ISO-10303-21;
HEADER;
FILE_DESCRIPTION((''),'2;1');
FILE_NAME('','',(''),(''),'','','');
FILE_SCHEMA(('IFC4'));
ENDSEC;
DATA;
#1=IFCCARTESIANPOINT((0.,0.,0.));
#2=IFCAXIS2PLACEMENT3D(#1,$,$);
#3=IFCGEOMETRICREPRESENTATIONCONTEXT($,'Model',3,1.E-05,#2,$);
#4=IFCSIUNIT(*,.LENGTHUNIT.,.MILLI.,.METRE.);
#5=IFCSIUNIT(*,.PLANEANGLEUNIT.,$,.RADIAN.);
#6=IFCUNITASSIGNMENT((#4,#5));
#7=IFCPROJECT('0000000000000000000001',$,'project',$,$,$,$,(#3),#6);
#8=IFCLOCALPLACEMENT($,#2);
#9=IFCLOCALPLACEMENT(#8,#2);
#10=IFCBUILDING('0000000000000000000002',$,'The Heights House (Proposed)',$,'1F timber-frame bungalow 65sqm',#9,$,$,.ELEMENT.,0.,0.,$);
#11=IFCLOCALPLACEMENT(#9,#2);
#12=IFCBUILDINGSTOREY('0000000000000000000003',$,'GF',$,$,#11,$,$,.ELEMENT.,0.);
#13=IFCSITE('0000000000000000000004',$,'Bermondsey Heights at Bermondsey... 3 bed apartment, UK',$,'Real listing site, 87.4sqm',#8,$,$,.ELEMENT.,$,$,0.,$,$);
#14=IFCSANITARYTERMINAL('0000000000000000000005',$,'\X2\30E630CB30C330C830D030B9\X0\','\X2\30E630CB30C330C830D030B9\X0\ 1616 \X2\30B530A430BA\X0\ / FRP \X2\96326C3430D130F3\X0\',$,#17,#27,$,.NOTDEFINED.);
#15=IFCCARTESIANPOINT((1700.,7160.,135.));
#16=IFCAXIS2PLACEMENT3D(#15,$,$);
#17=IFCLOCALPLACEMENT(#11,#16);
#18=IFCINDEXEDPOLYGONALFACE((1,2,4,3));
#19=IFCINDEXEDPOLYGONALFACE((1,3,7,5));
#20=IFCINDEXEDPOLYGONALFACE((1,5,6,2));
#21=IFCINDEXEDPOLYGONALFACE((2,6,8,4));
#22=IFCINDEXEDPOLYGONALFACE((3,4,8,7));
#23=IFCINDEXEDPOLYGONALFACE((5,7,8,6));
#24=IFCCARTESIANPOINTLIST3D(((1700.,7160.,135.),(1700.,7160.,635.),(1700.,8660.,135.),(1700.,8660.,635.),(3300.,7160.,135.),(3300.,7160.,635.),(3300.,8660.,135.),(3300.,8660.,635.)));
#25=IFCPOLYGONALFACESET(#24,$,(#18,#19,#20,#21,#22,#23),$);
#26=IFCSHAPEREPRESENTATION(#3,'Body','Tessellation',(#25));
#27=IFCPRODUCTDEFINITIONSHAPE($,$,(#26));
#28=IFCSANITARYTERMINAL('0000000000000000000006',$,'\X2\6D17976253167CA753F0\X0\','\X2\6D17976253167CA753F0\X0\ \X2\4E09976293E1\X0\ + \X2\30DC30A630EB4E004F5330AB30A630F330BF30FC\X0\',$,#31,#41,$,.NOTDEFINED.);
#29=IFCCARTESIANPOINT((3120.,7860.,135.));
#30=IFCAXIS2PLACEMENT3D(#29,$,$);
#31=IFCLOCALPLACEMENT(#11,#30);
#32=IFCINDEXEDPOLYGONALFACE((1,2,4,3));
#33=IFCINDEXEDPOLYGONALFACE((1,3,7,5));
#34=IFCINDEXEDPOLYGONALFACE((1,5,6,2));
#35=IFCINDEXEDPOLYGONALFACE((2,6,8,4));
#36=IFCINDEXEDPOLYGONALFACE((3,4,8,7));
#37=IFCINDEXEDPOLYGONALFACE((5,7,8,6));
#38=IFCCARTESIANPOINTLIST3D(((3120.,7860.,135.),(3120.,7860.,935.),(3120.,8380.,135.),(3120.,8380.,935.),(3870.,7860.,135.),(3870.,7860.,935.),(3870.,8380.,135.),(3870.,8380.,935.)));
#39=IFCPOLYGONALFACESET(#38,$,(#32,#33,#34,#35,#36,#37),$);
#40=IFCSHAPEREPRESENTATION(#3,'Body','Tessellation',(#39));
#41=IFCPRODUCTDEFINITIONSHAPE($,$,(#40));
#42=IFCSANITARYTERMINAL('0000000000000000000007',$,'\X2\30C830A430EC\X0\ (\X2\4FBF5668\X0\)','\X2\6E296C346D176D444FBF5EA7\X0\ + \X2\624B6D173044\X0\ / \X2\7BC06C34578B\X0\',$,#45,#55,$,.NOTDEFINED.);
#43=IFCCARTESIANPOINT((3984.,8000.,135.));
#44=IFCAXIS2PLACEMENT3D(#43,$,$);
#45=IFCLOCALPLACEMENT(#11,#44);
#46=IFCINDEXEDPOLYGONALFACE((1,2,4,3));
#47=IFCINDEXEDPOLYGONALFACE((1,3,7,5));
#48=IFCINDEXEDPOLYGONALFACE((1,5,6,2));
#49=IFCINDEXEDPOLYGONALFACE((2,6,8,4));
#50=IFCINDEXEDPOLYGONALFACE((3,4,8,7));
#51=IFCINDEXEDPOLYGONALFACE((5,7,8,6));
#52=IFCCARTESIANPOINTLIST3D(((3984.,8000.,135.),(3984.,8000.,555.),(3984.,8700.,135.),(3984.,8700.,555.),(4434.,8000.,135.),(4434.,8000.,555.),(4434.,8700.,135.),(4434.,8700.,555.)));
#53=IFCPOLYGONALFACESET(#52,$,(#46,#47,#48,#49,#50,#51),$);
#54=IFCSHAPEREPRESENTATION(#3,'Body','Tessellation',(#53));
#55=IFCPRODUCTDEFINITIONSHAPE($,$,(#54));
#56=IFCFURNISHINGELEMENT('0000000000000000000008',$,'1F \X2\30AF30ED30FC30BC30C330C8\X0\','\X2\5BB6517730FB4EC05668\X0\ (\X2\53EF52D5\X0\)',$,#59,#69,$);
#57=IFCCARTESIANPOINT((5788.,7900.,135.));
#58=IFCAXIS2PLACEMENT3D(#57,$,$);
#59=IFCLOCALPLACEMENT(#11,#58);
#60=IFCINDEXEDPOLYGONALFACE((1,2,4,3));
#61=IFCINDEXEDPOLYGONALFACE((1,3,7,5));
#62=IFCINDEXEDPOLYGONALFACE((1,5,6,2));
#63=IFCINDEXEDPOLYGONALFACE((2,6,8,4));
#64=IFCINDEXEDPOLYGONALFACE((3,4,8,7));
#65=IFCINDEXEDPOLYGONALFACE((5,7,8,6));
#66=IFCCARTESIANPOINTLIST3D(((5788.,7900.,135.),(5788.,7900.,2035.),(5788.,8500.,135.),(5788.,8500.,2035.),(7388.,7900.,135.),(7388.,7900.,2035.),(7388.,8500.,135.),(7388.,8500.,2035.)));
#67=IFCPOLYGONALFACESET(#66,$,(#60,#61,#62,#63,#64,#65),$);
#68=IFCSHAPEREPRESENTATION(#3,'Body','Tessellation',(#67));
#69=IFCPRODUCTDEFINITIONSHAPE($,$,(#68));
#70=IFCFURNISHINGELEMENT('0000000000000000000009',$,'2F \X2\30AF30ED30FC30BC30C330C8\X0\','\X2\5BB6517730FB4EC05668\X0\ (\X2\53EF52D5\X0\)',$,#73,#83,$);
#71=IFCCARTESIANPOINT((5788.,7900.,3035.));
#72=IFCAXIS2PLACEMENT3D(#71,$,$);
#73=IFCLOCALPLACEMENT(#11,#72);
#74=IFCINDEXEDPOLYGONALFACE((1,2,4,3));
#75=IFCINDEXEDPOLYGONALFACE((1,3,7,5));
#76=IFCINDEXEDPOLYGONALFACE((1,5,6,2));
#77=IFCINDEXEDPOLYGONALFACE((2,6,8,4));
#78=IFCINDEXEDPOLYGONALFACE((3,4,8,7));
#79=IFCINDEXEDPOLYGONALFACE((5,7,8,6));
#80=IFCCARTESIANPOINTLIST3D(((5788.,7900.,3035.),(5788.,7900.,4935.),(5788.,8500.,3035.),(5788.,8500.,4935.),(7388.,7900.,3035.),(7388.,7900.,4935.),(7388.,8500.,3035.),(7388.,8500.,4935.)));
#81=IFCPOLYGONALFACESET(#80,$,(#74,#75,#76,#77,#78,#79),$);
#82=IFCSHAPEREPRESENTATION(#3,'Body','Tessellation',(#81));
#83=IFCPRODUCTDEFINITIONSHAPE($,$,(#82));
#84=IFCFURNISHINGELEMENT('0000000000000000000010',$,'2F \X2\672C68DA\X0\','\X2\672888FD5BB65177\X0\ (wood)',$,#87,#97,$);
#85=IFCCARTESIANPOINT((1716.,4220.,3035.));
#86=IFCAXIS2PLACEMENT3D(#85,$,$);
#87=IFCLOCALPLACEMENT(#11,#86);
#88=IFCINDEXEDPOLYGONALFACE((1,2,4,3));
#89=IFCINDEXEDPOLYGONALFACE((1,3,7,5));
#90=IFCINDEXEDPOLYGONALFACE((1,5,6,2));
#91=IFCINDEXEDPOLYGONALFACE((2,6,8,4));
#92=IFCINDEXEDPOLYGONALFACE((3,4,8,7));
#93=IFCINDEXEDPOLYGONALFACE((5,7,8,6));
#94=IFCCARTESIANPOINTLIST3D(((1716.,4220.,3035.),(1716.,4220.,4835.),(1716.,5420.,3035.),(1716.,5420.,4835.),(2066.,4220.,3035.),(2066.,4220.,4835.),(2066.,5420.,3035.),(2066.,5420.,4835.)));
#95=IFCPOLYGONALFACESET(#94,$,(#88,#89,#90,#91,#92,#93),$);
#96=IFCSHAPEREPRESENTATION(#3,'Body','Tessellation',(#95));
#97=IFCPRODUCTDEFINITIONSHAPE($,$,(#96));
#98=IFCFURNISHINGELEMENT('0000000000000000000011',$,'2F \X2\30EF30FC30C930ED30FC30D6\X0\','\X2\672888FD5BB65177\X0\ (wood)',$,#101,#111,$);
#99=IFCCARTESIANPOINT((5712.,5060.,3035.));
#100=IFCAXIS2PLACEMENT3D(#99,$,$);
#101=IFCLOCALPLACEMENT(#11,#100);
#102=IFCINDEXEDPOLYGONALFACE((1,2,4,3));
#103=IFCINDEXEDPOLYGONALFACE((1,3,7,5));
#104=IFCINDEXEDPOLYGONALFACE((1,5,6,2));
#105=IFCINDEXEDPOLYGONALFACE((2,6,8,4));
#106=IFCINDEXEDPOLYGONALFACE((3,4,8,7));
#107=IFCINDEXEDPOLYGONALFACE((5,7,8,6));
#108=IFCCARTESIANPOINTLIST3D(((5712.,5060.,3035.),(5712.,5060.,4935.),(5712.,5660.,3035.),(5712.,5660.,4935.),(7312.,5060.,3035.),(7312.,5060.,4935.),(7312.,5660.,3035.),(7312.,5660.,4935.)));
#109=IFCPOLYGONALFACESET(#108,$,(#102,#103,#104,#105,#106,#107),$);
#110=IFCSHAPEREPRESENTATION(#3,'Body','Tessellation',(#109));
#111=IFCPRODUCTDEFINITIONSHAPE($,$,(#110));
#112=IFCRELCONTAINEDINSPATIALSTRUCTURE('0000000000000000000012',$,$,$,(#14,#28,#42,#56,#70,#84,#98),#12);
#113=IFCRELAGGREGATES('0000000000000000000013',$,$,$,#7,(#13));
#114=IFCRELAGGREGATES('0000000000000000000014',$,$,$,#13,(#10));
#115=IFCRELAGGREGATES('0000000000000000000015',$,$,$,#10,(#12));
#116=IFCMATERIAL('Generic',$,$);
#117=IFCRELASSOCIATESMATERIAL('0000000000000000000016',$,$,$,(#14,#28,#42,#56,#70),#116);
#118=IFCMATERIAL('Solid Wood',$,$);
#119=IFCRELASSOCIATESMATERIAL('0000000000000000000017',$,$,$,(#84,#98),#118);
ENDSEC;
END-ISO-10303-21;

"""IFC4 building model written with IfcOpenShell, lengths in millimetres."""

from ifc_helpers import new_model, si_unit, frame, frame_2d, origin, place, context, project, spatial, rectangle, extrude, material, element, save


model = new_model("IFC4")

# Units and contexts
model_context = context("Model", 3, precision=1e-05, world=origin())
ifc_project = project(units=[si_unit("LENGTHUNIT", "METRE", prefix="MILLI"), si_unit("PLANEANGLEUNIT", "RADIAN")], contexts=[model_context])

# Site, building, storey
site_placement = place(None, origin())
site = spatial("IfcSite", under=ifc_project, at=site_placement, Name="Bermondsey Heights at Bermondsey... 3 bed apartment, UK", ObjectType="Real listing site, 87.4sqm", CompositionType="ELEMENT", RefElevation=0.0)
building_placement = place(site_placement, origin())
building = spatial("IfcBuilding", under=site, at=building_placement, Name="The Heights House (Proposed)", ObjectType="1F timber-frame bungalow 65sqm", CompositionType="ELEMENT", ElevationOfRefHeight=0.0, ElevationOfTerrain=0.0)
storey_placement = place(building_placement, origin())
storey = spatial("IfcBuildingStorey", under=building, at=storey_placement, Name="GF", CompositionType="ELEMENT", Elevation=0.0)

# Shared definitions
ifc_material_1 = material(Name="Solid Wood")

# Shared definitions
ifc_material_2 = material(Name="Generic")

# Sanitary terminals
sanitary_terminal_1_placement = place(storey_placement, frame((1700.0, 7160.0, 135.0)))
element("IfcSanitaryTerminal", 1, at=sanitary_terminal_1_placement, inside=storey, material=ifc_material_2, Name="ユニットバス", Description="ユニットバス 1616 サイズ / FRP 防水パン", PredefinedType="NOTDEFINED", context=model_context, shape_type="SweptSolid", body=[
    extrude(rectangle(XDim=1600.0, YDim=1500.0, at=frame_2d((800.0, 750.0))), frame((1700.0, 7160.0, 135.0)), (0.0, 0.0, 1.0), 500.0),
])
sanitary_terminal_2_placement = place(storey_placement, frame((3120.0, 7860.0, 135.0)))
element("IfcSanitaryTerminal", 2, at=sanitary_terminal_2_placement, inside=storey, material=ifc_material_2, Name="洗面化粧台", Description="洗面化粧台 三面鏡 + ボウル一体カウンター", PredefinedType="NOTDEFINED", context=model_context, shape_type="SweptSolid", body=[
    extrude(rectangle(XDim=750.0, YDim=520.0, at=frame_2d((375.0, 260.0))), frame((3120.0, 7860.0, 135.0)), (0.0, 0.0, 1.0), 800.0),
])
sanitary_terminal_3_placement = place(storey_placement, frame((3984.0, 8000.0, 135.0)))
element("IfcSanitaryTerminal", 3, at=sanitary_terminal_3_placement, inside=storey, material=ifc_material_2, Name="トイレ (便器)", Description="温水洗浄便座 + 手洗い / 節水型", PredefinedType="NOTDEFINED", context=model_context, shape_type="SweptSolid", body=[
    extrude(rectangle(XDim=450.0, YDim=700.0, at=frame_2d((225.0, 350.0))), frame((3984.0, 8000.0, 135.0)), (0.0, 0.0, 1.0), 420.0),
])

# Furnishing elements
furnishing_1_placement = place(storey_placement, frame((5788.0, 7900.0, 135.0)))
element("IfcFurnishingElement", 4, at=furnishing_1_placement, inside=storey, material=ifc_material_2, Name="1F クローゼット", Description="家具・什器 (可動)", context=model_context, shape_type="SweptSolid", body=[
    extrude(rectangle(XDim=1600.0, YDim=600.0, at=frame_2d((800.0, 300.0))), frame((5788.0, 7900.0, 135.0)), (0.0, 0.0, 1.0), 1900.0),
])
furnishing_2_placement = place(storey_placement, frame((5788.0, 7900.0, 3035.0)))
element("IfcFurnishingElement", 5, at=furnishing_2_placement, inside=storey, material=ifc_material_2, Name="2F クローゼット", Description="家具・什器 (可動)", context=model_context, shape_type="SweptSolid", body=[
    extrude(rectangle(XDim=1600.0, YDim=600.0, at=frame_2d((800.0, 300.0))), frame((5788.0, 7900.0, 3035.0)), (0.0, 0.0, 1.0), 1900.0),
])
furnishing_3_placement = place(storey_placement, frame((1716.0, 4220.0, 3035.0)))
element("IfcFurnishingElement", 6, at=furnishing_3_placement, inside=storey, material=ifc_material_1, Name="2F 本棚", Description="木製家具 (wood)", context=model_context, shape_type="SweptSolid", body=[
    extrude(rectangle(XDim=350.0, YDim=1200.0, at=frame_2d((175.0, 600.0))), frame((1716.0, 4220.0, 3035.0)), (0.0, 0.0, 1.0), 1800.0),
])
furnishing_4_placement = place(storey_placement, frame((5712.0, 5060.0, 3035.0)))
element("IfcFurnishingElement", 7, at=furnishing_4_placement, inside=storey, material=ifc_material_1, Name="2F ワードローブ", Description="木製家具 (wood)", context=model_context, shape_type="SweptSolid", body=[
    extrude(rectangle(XDim=1600.0, YDim=600.0, at=frame_2d((800.0, 300.0))), frame((5712.0, 5060.0, 3035.0)), (0.0, 0.0, 1.0), 1900.0),
])

save(model, "model.ifc")
